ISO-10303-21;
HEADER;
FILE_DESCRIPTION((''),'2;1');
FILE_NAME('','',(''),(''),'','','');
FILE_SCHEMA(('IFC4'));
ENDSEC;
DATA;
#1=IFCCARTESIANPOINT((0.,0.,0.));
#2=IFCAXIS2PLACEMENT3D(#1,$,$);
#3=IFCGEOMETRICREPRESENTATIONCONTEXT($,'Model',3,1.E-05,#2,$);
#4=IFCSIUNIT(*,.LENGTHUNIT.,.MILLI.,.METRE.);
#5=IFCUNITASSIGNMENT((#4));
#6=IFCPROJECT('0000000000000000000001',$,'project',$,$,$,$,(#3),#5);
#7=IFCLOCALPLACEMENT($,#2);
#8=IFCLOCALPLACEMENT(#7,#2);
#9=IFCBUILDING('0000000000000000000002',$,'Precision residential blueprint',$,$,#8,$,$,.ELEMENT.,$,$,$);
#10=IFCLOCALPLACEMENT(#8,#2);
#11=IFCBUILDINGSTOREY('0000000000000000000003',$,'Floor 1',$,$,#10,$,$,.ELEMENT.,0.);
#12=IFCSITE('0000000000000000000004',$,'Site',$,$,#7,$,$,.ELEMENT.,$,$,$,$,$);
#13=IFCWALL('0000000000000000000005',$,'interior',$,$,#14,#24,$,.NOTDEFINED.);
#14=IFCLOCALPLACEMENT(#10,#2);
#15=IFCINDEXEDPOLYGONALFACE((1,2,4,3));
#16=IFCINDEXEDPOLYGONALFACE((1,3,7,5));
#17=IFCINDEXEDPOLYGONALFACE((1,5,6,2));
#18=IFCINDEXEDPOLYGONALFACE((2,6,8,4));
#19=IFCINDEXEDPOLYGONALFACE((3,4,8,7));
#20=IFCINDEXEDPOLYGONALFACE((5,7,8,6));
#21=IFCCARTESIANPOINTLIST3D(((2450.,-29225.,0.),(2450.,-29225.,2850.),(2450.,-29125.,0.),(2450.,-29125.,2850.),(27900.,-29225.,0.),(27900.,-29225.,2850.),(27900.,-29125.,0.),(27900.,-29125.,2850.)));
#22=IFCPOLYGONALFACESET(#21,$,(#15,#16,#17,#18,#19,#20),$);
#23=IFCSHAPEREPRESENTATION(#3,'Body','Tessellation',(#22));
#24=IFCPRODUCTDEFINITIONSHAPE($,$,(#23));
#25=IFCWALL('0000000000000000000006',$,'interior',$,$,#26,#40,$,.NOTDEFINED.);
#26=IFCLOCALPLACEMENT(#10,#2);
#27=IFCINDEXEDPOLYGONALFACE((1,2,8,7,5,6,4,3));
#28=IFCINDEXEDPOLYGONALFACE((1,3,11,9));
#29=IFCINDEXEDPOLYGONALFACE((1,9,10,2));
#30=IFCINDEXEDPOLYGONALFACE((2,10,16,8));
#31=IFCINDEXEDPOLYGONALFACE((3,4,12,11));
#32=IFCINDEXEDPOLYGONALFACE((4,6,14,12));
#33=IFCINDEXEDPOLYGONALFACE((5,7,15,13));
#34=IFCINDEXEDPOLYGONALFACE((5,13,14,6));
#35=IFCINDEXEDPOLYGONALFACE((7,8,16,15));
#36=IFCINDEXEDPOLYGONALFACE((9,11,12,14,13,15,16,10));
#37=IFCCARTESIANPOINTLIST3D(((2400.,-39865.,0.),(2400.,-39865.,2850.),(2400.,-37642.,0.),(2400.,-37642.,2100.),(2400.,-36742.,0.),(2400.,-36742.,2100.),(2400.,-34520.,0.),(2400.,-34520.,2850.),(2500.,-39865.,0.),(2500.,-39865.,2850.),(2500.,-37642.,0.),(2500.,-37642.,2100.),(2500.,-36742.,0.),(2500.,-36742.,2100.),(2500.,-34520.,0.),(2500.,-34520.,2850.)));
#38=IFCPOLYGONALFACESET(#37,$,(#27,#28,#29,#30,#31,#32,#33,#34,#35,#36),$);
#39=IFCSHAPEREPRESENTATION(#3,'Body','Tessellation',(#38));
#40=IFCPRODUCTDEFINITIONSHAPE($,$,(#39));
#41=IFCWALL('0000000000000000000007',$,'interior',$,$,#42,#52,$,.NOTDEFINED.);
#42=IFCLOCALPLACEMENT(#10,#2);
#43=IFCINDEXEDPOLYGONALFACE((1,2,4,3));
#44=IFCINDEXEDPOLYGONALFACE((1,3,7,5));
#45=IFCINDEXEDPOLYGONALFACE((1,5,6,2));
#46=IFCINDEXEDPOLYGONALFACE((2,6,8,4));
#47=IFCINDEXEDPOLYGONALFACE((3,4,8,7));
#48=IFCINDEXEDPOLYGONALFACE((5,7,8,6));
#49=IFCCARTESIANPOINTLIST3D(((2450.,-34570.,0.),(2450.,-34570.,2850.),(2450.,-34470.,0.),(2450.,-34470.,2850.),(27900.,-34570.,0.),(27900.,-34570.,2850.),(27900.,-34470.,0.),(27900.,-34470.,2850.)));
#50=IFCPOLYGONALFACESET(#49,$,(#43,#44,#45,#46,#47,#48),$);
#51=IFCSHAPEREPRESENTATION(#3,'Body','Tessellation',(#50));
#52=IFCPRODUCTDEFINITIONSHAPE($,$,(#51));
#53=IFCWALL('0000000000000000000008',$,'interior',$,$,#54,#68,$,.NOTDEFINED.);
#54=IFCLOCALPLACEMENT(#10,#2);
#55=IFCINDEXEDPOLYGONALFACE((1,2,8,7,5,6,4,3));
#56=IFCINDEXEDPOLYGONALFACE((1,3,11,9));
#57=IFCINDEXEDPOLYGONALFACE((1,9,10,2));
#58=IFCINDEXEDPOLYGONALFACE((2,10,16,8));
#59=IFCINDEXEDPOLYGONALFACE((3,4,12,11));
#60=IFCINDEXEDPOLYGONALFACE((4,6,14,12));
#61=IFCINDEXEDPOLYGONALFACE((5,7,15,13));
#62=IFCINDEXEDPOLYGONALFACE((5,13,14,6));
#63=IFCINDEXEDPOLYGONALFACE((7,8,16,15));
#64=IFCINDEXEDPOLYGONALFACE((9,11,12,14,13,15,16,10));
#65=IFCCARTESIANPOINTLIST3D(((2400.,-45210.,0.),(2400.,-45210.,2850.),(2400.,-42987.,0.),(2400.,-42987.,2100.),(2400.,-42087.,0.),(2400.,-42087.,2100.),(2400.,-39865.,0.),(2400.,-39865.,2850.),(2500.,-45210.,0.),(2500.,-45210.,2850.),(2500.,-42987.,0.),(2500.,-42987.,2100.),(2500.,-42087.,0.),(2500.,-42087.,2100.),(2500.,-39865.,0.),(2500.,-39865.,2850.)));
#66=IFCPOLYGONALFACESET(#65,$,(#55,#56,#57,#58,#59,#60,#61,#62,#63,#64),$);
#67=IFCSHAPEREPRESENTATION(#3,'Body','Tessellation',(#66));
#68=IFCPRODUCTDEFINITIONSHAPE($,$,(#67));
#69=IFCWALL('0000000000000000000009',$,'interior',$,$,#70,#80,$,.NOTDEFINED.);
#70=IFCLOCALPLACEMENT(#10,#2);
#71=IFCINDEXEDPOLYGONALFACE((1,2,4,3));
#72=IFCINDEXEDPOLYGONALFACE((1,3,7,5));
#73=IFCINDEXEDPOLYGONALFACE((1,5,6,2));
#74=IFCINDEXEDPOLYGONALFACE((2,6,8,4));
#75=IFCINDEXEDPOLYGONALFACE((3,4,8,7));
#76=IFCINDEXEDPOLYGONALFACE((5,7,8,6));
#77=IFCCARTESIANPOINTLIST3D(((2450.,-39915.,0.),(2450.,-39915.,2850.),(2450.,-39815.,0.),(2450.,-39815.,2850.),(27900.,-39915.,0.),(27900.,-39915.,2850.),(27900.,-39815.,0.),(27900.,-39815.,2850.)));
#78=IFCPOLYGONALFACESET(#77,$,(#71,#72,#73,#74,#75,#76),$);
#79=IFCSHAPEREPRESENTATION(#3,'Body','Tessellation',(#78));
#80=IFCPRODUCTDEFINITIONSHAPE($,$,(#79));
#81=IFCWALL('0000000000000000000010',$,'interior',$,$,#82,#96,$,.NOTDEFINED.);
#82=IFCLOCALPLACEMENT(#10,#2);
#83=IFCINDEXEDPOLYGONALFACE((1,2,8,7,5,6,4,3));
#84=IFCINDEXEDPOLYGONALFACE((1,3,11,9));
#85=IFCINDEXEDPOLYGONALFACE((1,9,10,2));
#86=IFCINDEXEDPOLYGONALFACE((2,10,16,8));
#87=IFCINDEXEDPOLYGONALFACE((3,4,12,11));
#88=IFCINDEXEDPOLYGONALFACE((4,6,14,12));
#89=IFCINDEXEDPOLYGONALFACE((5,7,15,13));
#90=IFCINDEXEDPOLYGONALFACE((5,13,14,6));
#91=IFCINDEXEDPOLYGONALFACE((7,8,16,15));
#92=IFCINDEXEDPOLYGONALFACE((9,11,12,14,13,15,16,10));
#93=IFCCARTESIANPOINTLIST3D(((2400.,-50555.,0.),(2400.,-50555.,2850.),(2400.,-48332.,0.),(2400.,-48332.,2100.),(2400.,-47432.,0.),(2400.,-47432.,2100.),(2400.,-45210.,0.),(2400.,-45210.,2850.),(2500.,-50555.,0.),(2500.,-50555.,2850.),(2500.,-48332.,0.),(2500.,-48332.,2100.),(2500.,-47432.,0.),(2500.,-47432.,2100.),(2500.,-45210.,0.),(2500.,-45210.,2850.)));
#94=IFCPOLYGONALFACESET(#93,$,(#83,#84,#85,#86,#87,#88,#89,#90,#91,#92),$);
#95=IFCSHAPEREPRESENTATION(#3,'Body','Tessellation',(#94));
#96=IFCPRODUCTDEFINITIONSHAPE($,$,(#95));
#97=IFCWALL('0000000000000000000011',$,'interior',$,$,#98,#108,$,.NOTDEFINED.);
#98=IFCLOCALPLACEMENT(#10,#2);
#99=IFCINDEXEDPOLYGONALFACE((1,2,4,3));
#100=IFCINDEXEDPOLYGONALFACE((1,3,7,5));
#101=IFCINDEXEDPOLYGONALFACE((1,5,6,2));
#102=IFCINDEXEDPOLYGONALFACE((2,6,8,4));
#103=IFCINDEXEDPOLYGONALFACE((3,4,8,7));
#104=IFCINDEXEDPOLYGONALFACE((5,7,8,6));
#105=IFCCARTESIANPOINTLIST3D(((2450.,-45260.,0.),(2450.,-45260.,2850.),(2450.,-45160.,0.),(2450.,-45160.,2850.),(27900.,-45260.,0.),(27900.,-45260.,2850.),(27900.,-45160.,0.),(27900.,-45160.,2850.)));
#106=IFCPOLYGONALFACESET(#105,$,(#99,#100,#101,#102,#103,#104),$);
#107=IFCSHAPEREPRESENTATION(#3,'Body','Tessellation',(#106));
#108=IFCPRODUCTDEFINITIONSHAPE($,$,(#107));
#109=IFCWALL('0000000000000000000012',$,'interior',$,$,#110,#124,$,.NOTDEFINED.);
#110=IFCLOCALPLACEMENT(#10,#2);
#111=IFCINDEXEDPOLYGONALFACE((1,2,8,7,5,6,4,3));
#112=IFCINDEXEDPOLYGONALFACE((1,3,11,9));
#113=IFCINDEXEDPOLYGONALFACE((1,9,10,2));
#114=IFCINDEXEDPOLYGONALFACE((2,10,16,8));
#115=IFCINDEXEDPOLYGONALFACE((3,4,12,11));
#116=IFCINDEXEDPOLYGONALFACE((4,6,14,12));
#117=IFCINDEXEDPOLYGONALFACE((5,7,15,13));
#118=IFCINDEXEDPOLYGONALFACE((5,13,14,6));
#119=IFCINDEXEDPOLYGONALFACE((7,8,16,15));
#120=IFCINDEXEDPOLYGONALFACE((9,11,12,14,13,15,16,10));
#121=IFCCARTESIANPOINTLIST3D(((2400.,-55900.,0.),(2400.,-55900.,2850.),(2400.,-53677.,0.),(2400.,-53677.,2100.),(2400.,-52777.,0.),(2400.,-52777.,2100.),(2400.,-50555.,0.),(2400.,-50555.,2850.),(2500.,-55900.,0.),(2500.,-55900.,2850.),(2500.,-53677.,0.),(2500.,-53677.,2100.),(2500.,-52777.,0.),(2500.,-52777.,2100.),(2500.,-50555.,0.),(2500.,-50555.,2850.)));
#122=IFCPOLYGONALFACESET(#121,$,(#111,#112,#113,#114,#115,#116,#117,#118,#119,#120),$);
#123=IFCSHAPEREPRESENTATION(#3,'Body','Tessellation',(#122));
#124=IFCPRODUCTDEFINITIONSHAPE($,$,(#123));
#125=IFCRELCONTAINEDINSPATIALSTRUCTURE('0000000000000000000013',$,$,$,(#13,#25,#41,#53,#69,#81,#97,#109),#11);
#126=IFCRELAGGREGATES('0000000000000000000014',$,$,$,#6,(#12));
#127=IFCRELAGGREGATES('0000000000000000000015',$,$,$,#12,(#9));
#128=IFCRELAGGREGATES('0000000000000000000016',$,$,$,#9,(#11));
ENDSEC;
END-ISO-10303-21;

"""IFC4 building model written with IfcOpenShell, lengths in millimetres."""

from ifc_helpers import new_model, si_unit, origin, place, context, project, spatial, polyline, outline, extrude, element, save


model = new_model("IFC4")

# Units and contexts
model_context = context("Model", 3, precision=1e-05, world=origin())
ifc_project = project(units=[si_unit("LENGTHUNIT", "METRE", prefix="MILLI")], contexts=[model_context])

# Site, building, storey
site_placement = place(None, origin())
site = spatial("IfcSite", under=ifc_project, at=site_placement, Name="Site", CompositionType="ELEMENT")
building_placement = place(site_placement, origin())
building = spatial("IfcBuilding", under=site, at=building_placement, Name="Precision residential blueprint", CompositionType="ELEMENT")
storey_placement = place(building_placement, origin())
storey = spatial("IfcBuildingStorey", under=building, at=storey_placement, Name="Floor 1", CompositionType="ELEMENT", Elevation=0.0)

# Wall
wall_1_placement = place(storey_placement, origin())
element("IfcWall", 1, at=wall_1_placement, inside=storey, Name="interior", PredefinedType="NOTDEFINED", context=model_context, shape_type="SweptSolid", body=[
    extrude(outline(polyline([(2450.0, -29125.0), (27900.0, -29125.0), (27900.0, -29225.0), (2450.0, -29225.0), (2450.0, -29125.0)])), origin(), (0.0, 0.0, 1.0), 2850.0),
])

# Wall, opening
wall_2_placement = place(storey_placement, origin())
wall_2 = element("IfcWall", 2, at=wall_2_placement, inside=storey, Name="interior", PredefinedType="NOTDEFINED", context=model_context, shape_type="SweptSolid", body=[
    extrude(outline(polyline([(2500.0, -34520.0), (2500.0, -39865.0), (2400.0, -39865.0), (2400.0, -34520.0), (2500.0, -34520.0)])), origin(), (0.0, 0.0, 1.0), 2850.0),
])
opening_1_placement = place(storey_placement, origin())
element("IfcOpeningElement", 3, at=opening_1_placement, cuts=wall_2, PredefinedType="OPENING", context=model_context, shape_type="SweptSolid", body=[
    extrude(outline(polyline([(2500.0, -36742.0), (2500.0, -37642.0), (2400.0, -37642.0), (2400.0, -36742.0), (2500.0, -36742.0)])), origin(), (0.0, 0.0, 1.0), 2100.0),
])

# Wall
wall_3_placement = place(storey_placement, origin())
element("IfcWall", 4, at=wall_3_placement, inside=storey, Name="interior", PredefinedType="NOTDEFINED", context=model_context, shape_type="SweptSolid", body=[
    extrude(outline(polyline([(2450.0, -34470.0), (27900.0, -34470.0), (27900.0, -34570.0), (2450.0, -34570.0), (2450.0, -34470.0)])), origin(), (0.0, 0.0, 1.0), 2850.0),
])

# Wall, opening
wall_4_placement = place(storey_placement, origin())
wall_4 = element("IfcWall", 5, at=wall_4_placement, inside=storey, Name="interior", PredefinedType="NOTDEFINED", context=model_context, shape_type="SweptSolid", body=[
    extrude(outline(polyline([(2500.0, -39865.0), (2500.0, -45210.0), (2400.0, -45210.0), (2400.0, -39865.0), (2500.0, -39865.0)])), origin(), (0.0, 0.0, 1.0), 2850.0),
])
opening_2_placement = place(storey_placement, origin())
element("IfcOpeningElement", 6, at=opening_2_placement, cuts=wall_4, PredefinedType="OPENING", context=model_context, shape_type="SweptSolid", body=[
    extrude(outline(polyline([(2500.0, -42087.0), (2500.0, -42987.0), (2400.0, -42987.0), (2400.0, -42087.0), (2500.0, -42087.0)])), origin(), (0.0, 0.0, 1.0), 2100.0),
])

# Wall
wall_5_placement = place(storey_placement, origin())
element("IfcWall", 7, at=wall_5_placement, inside=storey, Name="interior", PredefinedType="NOTDEFINED", context=model_context, shape_type="SweptSolid", body=[
    extrude(outline(polyline([(2450.0, -39815.0), (27900.0, -39815.0), (27900.0, -39915.0), (2450.0, -39915.0), (2450.0, -39815.0)])), origin(), (0.0, 0.0, 1.0), 2850.0),
])

# Wall, opening
wall_6_placement = place(storey_placement, origin())
wall_6 = element("IfcWall", 8, at=wall_6_placement, inside=storey, Name="interior", PredefinedType="NOTDEFINED", context=model_context, shape_type="SweptSolid", body=[
    extrude(outline(polyline([(2500.0, -45210.0), (2500.0, -50555.0), (2400.0, -50555.0), (2400.0, -45210.0), (2500.0, -45210.0)])), origin(), (0.0, 0.0, 1.0), 2850.0),
])
opening_3_placement = place(storey_placement, origin())
element("IfcOpeningElement", 9, at=opening_3_placement, cuts=wall_6, PredefinedType="OPENING", context=model_context, shape_type="SweptSolid", body=[
    extrude(outline(polyline([(2500.0, -47432.0), (2500.0, -48332.0), (2400.0, -48332.0), (2400.0, -47432.0), (2500.0, -47432.0)])), origin(), (0.0, 0.0, 1.0), 2100.0),
])

# Wall
wall_7_placement = place(storey_placement, origin())
element("IfcWall", 10, at=wall_7_placement, inside=storey, Name="interior", PredefinedType="NOTDEFINED", context=model_context, shape_type="SweptSolid", body=[
    extrude(outline(polyline([(2450.0, -45160.0), (27900.0, -45160.0), (27900.0, -45260.0), (2450.0, -45260.0), (2450.0, -45160.0)])), origin(), (0.0, 0.0, 1.0), 2850.0),
])

# Wall, opening
wall_8_placement = place(storey_placement, origin())
wall_8 = element("IfcWall", 11, at=wall_8_placement, inside=storey, Name="interior", PredefinedType="NOTDEFINED", context=model_context, shape_type="SweptSolid", body=[
    extrude(outline(polyline([(2500.0, -50555.0), (2500.0, -55900.0), (2400.0, -55900.0), (2400.0, -50555.0), (2500.0, -50555.0)])), origin(), (0.0, 0.0, 1.0), 2850.0),
])
opening_4_placement = place(storey_placement, origin())
element("IfcOpeningElement", 12, at=opening_4_placement, cuts=wall_8, PredefinedType="OPENING", context=model_context, shape_type="SweptSolid", body=[
    extrude(outline(polyline([(2500.0, -52777.0), (2500.0, -53677.0), (2400.0, -53677.0), (2400.0, -52777.0), (2500.0, -52777.0)])), origin(), (0.0, 0.0, 1.0), 2100.0),
])

save(model, "model.ifc")
